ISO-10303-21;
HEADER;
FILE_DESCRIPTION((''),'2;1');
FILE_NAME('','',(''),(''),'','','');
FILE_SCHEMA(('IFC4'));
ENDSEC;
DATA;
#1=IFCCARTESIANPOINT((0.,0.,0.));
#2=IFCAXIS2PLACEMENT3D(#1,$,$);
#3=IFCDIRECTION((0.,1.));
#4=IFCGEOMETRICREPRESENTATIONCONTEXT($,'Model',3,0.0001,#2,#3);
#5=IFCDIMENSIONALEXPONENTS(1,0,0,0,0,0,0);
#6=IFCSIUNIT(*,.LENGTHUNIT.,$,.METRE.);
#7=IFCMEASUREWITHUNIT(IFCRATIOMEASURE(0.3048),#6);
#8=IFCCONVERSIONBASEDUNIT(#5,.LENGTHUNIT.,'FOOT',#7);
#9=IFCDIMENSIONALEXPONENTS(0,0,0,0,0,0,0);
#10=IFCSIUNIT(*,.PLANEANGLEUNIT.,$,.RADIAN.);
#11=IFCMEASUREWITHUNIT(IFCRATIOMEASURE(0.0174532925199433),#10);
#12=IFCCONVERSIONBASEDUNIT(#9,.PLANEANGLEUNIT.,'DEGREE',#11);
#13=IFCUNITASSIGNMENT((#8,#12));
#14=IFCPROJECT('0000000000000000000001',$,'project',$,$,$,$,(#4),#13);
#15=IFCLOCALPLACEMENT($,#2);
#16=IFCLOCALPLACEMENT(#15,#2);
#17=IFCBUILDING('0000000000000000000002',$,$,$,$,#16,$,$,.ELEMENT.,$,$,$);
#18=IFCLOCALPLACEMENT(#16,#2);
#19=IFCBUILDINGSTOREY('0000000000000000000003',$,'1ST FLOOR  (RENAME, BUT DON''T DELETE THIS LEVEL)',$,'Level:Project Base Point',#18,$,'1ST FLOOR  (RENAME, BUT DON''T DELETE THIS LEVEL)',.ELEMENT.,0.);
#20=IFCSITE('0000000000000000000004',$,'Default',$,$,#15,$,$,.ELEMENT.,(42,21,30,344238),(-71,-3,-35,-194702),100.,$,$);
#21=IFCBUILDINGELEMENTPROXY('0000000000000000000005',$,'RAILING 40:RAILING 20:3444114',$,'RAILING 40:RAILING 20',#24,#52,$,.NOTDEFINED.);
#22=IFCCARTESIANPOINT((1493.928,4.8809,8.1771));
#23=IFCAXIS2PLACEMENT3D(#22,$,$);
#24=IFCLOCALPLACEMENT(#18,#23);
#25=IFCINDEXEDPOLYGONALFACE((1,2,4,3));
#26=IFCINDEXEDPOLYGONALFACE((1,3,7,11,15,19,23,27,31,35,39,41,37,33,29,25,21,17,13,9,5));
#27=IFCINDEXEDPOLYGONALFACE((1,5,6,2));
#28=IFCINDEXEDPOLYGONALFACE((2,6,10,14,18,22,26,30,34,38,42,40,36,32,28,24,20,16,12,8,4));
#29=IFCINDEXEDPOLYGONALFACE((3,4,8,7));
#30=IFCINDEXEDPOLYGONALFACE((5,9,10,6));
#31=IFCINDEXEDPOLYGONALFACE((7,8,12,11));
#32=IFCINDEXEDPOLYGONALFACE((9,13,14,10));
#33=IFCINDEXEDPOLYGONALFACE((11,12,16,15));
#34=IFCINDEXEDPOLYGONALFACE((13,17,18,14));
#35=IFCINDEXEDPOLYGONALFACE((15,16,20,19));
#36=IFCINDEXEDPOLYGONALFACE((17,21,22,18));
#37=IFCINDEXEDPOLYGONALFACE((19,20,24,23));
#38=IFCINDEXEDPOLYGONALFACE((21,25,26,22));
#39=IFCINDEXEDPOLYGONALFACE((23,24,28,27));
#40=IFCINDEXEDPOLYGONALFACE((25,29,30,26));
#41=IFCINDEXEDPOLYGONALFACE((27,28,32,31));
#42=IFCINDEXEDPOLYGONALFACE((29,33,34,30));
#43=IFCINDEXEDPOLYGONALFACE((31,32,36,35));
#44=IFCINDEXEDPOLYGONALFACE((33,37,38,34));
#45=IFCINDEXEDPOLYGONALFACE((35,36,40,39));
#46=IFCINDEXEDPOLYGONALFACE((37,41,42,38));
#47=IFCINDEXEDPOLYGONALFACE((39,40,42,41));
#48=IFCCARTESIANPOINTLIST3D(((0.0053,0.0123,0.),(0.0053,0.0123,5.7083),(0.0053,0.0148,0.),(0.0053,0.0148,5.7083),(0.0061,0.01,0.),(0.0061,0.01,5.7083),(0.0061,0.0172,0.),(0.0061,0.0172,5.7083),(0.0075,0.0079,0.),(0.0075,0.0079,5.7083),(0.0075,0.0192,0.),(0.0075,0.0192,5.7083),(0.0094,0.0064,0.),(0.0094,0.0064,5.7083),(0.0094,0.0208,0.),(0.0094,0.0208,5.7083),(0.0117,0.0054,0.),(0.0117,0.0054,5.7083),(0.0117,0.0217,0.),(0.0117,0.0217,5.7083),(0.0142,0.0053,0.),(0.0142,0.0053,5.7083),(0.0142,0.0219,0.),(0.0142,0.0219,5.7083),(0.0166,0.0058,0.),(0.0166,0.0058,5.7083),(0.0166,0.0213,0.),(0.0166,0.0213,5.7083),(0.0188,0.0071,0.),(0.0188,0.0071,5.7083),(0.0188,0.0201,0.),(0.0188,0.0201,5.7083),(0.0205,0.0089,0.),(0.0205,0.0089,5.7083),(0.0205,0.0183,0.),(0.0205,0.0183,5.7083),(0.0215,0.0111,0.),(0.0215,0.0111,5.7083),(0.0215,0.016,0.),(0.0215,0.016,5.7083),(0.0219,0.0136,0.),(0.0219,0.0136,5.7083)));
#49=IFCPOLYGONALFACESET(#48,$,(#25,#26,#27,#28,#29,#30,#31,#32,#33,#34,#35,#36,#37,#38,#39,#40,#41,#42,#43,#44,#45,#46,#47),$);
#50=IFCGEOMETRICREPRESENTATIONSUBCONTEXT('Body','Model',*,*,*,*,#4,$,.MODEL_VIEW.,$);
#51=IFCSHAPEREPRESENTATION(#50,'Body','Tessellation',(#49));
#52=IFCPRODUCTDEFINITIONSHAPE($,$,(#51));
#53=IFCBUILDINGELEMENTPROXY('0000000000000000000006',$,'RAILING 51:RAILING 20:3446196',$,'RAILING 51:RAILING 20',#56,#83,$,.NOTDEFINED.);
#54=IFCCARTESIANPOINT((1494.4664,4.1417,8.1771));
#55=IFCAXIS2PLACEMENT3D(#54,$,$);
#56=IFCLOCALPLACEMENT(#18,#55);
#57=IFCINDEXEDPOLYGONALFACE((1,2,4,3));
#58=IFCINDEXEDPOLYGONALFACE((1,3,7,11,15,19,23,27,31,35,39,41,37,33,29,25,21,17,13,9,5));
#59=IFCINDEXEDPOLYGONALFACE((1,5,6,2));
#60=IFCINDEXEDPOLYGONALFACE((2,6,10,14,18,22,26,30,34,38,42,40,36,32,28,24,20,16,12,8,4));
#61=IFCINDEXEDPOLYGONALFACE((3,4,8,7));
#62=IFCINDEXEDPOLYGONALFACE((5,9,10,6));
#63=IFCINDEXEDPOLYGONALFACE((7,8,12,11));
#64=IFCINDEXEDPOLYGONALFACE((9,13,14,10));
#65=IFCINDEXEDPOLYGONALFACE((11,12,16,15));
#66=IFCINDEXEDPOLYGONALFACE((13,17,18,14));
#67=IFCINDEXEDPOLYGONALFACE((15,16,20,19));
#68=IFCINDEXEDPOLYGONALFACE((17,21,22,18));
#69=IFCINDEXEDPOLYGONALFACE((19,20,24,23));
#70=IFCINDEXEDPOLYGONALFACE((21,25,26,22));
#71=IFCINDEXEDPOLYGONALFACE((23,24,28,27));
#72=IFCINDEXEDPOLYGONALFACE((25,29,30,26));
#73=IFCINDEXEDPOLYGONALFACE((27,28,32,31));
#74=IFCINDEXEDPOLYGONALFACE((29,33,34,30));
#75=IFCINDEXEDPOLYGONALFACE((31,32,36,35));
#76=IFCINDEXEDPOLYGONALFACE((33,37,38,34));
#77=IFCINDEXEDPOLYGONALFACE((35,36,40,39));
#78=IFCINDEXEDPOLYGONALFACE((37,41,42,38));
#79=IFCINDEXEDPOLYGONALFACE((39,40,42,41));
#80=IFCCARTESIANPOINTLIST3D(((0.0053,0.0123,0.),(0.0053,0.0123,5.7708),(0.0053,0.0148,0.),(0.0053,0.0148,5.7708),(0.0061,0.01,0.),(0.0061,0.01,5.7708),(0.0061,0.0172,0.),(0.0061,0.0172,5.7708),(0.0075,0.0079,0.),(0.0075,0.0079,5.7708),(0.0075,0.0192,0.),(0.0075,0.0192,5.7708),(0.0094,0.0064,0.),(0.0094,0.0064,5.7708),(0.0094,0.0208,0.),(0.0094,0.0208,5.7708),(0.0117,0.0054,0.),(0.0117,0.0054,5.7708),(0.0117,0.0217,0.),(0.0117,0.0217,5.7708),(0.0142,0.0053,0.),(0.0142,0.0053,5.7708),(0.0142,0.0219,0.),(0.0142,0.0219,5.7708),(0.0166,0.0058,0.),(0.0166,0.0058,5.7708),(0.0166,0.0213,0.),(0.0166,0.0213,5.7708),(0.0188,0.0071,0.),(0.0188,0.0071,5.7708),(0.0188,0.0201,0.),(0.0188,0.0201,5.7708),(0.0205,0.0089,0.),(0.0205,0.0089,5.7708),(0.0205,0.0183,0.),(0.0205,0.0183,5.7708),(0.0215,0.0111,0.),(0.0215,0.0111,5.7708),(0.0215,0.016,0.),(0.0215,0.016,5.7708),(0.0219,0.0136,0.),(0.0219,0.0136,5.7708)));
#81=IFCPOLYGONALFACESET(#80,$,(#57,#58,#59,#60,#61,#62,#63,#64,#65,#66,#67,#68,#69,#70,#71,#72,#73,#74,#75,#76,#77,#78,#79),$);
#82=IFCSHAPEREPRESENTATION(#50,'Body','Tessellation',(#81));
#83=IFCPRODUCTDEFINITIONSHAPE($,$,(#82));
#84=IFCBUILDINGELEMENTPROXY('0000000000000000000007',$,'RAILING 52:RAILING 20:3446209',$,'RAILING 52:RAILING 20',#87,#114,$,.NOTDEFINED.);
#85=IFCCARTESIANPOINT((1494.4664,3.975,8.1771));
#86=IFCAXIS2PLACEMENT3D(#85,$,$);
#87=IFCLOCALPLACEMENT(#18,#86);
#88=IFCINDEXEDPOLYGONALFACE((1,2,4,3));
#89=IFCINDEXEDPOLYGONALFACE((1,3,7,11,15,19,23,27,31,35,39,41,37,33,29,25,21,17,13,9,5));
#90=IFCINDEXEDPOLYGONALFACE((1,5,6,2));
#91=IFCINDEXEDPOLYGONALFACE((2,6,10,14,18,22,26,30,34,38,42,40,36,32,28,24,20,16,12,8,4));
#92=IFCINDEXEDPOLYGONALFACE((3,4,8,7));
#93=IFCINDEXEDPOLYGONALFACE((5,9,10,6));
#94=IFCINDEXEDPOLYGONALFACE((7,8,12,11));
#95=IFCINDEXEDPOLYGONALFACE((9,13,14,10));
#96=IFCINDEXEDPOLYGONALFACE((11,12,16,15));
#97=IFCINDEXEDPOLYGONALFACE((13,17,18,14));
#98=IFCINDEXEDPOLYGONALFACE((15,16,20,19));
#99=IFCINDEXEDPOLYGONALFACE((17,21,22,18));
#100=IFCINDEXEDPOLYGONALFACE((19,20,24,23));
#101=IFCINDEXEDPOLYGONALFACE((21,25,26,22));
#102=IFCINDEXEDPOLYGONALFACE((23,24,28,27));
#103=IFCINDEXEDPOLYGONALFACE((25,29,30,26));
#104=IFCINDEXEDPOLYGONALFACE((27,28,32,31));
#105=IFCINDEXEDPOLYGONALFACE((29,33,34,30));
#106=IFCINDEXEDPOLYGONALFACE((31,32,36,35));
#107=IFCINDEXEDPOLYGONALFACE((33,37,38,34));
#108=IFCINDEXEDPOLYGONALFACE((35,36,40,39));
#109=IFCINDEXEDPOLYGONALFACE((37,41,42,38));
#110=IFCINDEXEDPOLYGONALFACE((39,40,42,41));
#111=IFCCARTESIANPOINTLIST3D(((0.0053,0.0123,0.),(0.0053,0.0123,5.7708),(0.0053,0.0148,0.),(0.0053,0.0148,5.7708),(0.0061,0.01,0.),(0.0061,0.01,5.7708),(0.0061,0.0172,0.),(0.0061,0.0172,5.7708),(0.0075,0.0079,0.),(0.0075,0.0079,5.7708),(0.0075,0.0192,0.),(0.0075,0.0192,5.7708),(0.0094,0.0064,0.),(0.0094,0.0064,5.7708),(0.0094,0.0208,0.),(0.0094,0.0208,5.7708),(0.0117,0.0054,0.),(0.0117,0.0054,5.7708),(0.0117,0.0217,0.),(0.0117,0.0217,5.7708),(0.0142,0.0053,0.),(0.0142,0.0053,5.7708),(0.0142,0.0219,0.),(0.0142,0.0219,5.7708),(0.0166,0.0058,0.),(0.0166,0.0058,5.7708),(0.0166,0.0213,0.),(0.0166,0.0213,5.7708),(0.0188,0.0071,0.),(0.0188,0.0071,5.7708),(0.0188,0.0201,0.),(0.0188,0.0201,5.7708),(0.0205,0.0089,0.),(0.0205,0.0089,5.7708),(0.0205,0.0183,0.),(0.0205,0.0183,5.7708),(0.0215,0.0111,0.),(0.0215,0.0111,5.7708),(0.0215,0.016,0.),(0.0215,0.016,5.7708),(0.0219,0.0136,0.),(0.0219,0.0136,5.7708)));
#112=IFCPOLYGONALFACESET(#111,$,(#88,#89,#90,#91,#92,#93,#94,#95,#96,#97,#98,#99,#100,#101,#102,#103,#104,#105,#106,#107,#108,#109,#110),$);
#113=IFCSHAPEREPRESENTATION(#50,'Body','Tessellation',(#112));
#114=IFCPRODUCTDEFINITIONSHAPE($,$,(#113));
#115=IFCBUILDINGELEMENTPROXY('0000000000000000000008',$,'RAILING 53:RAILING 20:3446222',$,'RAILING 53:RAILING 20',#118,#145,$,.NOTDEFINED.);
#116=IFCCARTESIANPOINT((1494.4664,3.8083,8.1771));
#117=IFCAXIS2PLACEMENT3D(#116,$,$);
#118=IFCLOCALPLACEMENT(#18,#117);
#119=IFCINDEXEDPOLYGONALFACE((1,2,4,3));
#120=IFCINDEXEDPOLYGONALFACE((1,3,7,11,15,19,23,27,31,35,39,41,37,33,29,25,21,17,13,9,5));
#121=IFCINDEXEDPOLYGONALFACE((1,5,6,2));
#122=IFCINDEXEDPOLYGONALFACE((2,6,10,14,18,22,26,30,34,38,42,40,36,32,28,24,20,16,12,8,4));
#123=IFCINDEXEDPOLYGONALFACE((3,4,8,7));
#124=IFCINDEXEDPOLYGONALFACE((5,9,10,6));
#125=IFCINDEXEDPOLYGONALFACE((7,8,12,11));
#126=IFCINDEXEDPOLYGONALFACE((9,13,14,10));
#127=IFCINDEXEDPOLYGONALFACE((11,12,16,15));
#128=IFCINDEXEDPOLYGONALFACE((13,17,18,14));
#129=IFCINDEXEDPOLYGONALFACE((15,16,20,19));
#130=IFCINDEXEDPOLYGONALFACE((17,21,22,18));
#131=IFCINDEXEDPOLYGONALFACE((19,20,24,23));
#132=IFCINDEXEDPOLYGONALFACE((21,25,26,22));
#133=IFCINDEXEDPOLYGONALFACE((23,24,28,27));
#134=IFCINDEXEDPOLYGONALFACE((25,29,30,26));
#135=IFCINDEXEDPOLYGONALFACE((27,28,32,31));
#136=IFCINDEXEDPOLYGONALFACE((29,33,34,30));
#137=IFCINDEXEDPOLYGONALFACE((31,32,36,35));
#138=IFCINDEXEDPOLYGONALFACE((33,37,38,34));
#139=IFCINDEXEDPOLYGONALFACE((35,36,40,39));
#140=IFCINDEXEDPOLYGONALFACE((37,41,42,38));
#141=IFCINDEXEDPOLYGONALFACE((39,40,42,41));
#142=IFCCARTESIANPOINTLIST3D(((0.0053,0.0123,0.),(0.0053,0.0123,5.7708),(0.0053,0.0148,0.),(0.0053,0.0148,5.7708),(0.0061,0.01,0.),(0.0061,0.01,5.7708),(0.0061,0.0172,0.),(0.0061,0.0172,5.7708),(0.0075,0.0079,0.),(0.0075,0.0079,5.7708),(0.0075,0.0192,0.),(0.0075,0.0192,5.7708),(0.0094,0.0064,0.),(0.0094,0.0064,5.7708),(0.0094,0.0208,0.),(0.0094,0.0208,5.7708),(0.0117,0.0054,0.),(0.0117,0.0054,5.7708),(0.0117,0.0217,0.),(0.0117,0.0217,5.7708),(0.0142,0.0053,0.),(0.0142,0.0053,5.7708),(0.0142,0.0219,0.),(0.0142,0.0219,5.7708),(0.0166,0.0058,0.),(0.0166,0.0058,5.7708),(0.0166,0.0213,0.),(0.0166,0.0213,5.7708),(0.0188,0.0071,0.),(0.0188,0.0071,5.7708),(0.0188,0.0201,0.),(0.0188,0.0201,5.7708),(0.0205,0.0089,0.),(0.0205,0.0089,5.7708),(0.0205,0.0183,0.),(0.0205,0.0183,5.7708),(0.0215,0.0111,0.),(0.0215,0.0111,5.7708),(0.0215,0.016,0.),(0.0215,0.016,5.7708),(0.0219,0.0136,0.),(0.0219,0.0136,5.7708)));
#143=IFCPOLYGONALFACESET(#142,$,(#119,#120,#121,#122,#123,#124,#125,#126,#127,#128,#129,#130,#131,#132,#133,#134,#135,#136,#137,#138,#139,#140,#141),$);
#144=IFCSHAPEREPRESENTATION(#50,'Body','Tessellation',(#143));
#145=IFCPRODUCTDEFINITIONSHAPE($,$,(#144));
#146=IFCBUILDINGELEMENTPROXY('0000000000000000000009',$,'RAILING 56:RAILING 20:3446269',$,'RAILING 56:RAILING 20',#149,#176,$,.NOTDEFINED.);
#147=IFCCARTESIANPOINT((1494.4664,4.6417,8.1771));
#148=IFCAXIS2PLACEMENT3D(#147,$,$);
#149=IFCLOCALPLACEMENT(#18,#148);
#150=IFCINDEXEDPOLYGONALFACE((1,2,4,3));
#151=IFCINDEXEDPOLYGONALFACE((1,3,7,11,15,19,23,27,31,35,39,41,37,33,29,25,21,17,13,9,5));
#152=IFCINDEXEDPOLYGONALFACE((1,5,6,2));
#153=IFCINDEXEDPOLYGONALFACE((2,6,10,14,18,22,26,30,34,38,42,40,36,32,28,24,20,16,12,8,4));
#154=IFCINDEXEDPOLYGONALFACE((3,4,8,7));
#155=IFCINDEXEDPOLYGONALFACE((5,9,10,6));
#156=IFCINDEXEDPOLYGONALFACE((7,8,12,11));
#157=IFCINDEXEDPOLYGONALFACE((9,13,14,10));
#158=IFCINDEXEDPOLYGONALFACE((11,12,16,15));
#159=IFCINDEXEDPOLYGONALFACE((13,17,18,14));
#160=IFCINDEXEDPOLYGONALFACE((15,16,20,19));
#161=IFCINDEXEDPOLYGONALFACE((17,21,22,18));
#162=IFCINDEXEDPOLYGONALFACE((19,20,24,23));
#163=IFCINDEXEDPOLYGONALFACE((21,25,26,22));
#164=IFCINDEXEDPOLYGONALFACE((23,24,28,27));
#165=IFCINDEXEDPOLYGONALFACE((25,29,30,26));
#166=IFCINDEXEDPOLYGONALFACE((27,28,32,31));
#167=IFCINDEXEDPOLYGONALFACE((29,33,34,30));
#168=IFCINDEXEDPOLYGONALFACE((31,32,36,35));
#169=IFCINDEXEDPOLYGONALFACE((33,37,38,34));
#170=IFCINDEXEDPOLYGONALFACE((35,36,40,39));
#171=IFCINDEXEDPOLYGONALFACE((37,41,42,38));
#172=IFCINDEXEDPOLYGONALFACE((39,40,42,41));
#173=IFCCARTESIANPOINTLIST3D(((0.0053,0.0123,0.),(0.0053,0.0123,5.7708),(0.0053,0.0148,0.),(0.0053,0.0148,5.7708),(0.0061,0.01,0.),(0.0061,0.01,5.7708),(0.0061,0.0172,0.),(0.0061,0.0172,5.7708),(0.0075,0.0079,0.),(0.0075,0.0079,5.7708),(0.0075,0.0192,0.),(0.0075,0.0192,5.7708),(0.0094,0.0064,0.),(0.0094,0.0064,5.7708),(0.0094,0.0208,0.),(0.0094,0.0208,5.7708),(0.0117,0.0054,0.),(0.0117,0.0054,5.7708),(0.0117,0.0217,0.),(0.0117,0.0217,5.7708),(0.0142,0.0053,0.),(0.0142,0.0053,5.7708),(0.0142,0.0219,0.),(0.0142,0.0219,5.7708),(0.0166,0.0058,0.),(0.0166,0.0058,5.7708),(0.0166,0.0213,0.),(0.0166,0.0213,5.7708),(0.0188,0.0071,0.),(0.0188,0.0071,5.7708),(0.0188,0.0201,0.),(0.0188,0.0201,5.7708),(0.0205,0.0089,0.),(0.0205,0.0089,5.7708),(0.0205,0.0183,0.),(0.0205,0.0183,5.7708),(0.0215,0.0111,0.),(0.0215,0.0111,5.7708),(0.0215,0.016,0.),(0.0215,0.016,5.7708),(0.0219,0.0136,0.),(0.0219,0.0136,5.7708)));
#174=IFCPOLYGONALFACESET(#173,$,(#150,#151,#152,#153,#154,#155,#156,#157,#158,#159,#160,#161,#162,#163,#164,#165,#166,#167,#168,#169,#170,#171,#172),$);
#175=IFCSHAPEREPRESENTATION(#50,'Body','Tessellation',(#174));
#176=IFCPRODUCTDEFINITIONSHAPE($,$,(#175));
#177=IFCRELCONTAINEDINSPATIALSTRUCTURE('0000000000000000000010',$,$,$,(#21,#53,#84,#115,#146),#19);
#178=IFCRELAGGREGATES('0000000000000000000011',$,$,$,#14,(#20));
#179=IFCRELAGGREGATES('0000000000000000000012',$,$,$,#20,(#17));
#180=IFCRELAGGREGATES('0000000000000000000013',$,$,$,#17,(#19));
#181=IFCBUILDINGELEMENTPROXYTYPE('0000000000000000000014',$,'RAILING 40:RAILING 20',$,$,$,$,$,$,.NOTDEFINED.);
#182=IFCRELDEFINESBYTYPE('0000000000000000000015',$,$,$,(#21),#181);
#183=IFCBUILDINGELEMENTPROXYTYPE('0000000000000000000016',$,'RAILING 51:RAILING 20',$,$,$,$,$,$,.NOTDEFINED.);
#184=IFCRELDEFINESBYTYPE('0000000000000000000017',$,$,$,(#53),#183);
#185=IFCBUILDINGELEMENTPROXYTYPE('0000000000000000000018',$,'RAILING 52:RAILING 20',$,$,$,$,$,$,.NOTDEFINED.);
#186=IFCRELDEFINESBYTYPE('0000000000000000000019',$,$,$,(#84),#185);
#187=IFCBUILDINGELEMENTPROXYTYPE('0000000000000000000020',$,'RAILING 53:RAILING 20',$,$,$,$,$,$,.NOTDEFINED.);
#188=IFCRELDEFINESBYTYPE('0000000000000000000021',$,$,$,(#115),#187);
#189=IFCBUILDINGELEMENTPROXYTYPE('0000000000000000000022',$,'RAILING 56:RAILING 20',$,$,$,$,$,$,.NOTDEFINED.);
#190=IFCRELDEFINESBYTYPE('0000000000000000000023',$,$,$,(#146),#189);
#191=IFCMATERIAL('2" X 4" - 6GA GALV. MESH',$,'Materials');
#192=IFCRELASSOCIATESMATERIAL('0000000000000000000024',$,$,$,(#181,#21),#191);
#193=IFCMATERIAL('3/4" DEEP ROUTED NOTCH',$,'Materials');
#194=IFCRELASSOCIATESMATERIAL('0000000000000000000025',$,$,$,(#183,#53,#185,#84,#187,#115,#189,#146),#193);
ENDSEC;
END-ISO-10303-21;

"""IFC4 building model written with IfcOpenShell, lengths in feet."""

from ifc_helpers import new_model, entity, si_unit, converted_unit, direction, frame, origin, origin_2d_with_axis, place, context, subcontext, project, spatial, circle, extrude, source, transform, mapped, material, type_object, type_shapes, element, save


model = new_model("IFC4")

# Units and contexts
model_context = context("Model", 3, precision=0.0001, world=origin(), true_north=direction((0.0, 1.0)))
body_context = subcontext(model_context, "Body", "Model", "MODEL_VIEW")
ifc_project = project(units=[converted_unit("LENGTHUNIT", "FOOT", entity("IfcRatioMeasure", 0.3048), si_unit("LENGTHUNIT", "METRE"), dimensions=[1, 0, 0, 0, 0, 0, 0]), converted_unit("PLANEANGLEUNIT", "DEGREE", entity("IfcRatioMeasure", 0.0174532925199433), si_unit("PLANEANGLEUNIT", "RADIAN"), dimensions=[0, 0, 0, 0, 0, 0, 0])], contexts=[model_context])

# Site, building, storey
site_placement = place(None, origin())
site = spatial("IfcSite", under=ifc_project, at=site_placement, Name="Default", CompositionType="ELEMENT", RefLatitude=(42, 21, 30, 344238), RefLongitude=(-71, -3, -35, -194702), RefElevation=100.0)
building_placement = place(site_placement, origin())
building = spatial("IfcBuilding", under=site, at=building_placement, CompositionType="ELEMENT")
storey_placement = place(building_placement, origin())
storey = spatial("IfcBuildingStorey", under=building, at=storey_placement, Name="1ST FLOOR  (RENAME, BUT DON'T DELETE THIS LEVEL)", ObjectType="Level:Project Base Point", LongName="1ST FLOOR  (RENAME, BUT DON'T DELETE THIS LEVEL)", CompositionType="ELEMENT", Elevation=0.0)

# Building element proxies
ifc_material_1 = material(Name="2\" X 4\" - 6GA GALV. MESH", Category="Materials")
building_element_proxy_type_1 = type_object("IfcBuildingElementProxyType", Name="RAILING 40:RAILING 20", PredefinedType="NOTDEFINED", material=ifc_material_1)
shared_shape_1 = source(origin(), body_context, "Body", "SweptSolid", [
    extrude(circle(Radius=0.0083, at=origin_2d_with_axis()), frame((0.0136, 0.0136, 0.0)), (0.0, 0.0, 1.0), 5.7083),
])
type_shapes(building_element_proxy_type_1, [shared_shape_1])
proxy_1_placement = place(storey_placement, frame((1493.928, 4.8809, 8.1771)))
element("IfcBuildingElementProxy", 1, at=proxy_1_placement, inside=storey, type_object=building_element_proxy_type_1, material=ifc_material_1, Name="RAILING 40:RAILING 20:3444114", ObjectType="RAILING 40:RAILING 20", PredefinedType="NOTDEFINED", context=body_context, shape_type="MappedRepresentation", body=[
    mapped(shared_shape_1, transform((0.0, 0.0, 0.0), scale=1.0)),
])
ifc_material_2 = material(Name="3/4\" DEEP ROUTED NOTCH", Category="Materials")
building_element_proxy_type_2 = type_object("IfcBuildingElementProxyType", Name="RAILING 51:RAILING 20", PredefinedType="NOTDEFINED", material=ifc_material_2)
shared_shape_2 = source(origin(), body_context, "Body", "SweptSolid", [
    extrude(circle(Radius=0.0083, at=origin_2d_with_axis()), frame((0.0136, 0.0136, 0.0)), (0.0, 0.0, 1.0), 5.7708),
])
type_shapes(building_element_proxy_type_2, [shared_shape_2])
proxy_2_placement = place(storey_placement, frame((1494.4664, 4.1417, 8.1771)))
element("IfcBuildingElementProxy", 2, at=proxy_2_placement, inside=storey, type_object=building_element_proxy_type_2, material=ifc_material_2, Name="RAILING 51:RAILING 20:3446196", ObjectType="RAILING 51:RAILING 20", PredefinedType="NOTDEFINED", context=body_context, shape_type="MappedRepresentation", body=[
    mapped(shared_shape_2, transform((0.0, 0.0, 0.0), scale=1.0)),
])
building_element_proxy_type_3 = type_object("IfcBuildingElementProxyType", Name="RAILING 52:RAILING 20", PredefinedType="NOTDEFINED", material=ifc_material_2)
shared_shape_3 = source(origin(), body_context, "Body", "SweptSolid", [
    extrude(circle(Radius=0.0083, at=origin_2d_with_axis()), frame((0.0136, 0.0136, 0.0)), (0.0, 0.0, 1.0), 5.7708),
])
type_shapes(building_element_proxy_type_3, [shared_shape_3])
proxy_3_placement = place(storey_placement, frame((1494.4664, 3.975, 8.1771)))
element("IfcBuildingElementProxy", 3, at=proxy_3_placement, inside=storey, type_object=building_element_proxy_type_3, material=ifc_material_2, Name="RAILING 52:RAILING 20:3446209", ObjectType="RAILING 52:RAILING 20", PredefinedType="NOTDEFINED", context=body_context, shape_type="MappedRepresentation", body=[
    mapped(shared_shape_3, transform((0.0, 0.0, 0.0), scale=1.0)),
])
building_element_proxy_type_4 = type_object("IfcBuildingElementProxyType", Name="RAILING 53:RAILING 20", PredefinedType="NOTDEFINED", material=ifc_material_2)
shared_shape_4 = source(origin(), body_context, "Body", "SweptSolid", [
    extrude(circle(Radius=0.0083, at=origin_2d_with_axis()), frame((0.0136, 0.0136, 0.0)), (0.0, 0.0, 1.0), 5.7708),
])
type_shapes(building_element_proxy_type_4, [shared_shape_4])
proxy_4_placement = place(storey_placement, frame((1494.4664, 3.8083, 8.1771)))
element("IfcBuildingElementProxy", 4, at=proxy_4_placement, inside=storey, type_object=building_element_proxy_type_4, material=ifc_material_2, Name="RAILING 53:RAILING 20:3446222", ObjectType="RAILING 53:RAILING 20", PredefinedType="NOTDEFINED", context=body_context, shape_type="MappedRepresentation", body=[
    mapped(shared_shape_4, transform((0.0, 0.0, 0.0), scale=1.0)),
])
building_element_proxy_type_5 = type_object("IfcBuildingElementProxyType", Name="RAILING 56:RAILING 20", PredefinedType="NOTDEFINED", material=ifc_material_2)
shared_shape_5 = source(origin(), body_context, "Body", "SweptSolid", [
    extrude(circle(Radius=0.0083, at=origin_2d_with_axis()), frame((0.0136, 0.0136, 0.0)), (0.0, 0.0, 1.0), 5.7708),
])
type_shapes(building_element_proxy_type_5, [shared_shape_5])
proxy_5_placement = place(storey_placement, frame((1494.4664, 4.6417, 8.1771)))
element("IfcBuildingElementProxy", 5, at=proxy_5_placement, inside=storey, type_object=building_element_proxy_type_5, material=ifc_material_2, Name="RAILING 56:RAILING 20:3446269", ObjectType="RAILING 56:RAILING 20", PredefinedType="NOTDEFINED", context=body_context, shape_type="MappedRepresentation", body=[
    mapped(shared_shape_5, transform((0.0, 0.0, 0.0), scale=1.0)),
])

save(model, "model.ifc")
